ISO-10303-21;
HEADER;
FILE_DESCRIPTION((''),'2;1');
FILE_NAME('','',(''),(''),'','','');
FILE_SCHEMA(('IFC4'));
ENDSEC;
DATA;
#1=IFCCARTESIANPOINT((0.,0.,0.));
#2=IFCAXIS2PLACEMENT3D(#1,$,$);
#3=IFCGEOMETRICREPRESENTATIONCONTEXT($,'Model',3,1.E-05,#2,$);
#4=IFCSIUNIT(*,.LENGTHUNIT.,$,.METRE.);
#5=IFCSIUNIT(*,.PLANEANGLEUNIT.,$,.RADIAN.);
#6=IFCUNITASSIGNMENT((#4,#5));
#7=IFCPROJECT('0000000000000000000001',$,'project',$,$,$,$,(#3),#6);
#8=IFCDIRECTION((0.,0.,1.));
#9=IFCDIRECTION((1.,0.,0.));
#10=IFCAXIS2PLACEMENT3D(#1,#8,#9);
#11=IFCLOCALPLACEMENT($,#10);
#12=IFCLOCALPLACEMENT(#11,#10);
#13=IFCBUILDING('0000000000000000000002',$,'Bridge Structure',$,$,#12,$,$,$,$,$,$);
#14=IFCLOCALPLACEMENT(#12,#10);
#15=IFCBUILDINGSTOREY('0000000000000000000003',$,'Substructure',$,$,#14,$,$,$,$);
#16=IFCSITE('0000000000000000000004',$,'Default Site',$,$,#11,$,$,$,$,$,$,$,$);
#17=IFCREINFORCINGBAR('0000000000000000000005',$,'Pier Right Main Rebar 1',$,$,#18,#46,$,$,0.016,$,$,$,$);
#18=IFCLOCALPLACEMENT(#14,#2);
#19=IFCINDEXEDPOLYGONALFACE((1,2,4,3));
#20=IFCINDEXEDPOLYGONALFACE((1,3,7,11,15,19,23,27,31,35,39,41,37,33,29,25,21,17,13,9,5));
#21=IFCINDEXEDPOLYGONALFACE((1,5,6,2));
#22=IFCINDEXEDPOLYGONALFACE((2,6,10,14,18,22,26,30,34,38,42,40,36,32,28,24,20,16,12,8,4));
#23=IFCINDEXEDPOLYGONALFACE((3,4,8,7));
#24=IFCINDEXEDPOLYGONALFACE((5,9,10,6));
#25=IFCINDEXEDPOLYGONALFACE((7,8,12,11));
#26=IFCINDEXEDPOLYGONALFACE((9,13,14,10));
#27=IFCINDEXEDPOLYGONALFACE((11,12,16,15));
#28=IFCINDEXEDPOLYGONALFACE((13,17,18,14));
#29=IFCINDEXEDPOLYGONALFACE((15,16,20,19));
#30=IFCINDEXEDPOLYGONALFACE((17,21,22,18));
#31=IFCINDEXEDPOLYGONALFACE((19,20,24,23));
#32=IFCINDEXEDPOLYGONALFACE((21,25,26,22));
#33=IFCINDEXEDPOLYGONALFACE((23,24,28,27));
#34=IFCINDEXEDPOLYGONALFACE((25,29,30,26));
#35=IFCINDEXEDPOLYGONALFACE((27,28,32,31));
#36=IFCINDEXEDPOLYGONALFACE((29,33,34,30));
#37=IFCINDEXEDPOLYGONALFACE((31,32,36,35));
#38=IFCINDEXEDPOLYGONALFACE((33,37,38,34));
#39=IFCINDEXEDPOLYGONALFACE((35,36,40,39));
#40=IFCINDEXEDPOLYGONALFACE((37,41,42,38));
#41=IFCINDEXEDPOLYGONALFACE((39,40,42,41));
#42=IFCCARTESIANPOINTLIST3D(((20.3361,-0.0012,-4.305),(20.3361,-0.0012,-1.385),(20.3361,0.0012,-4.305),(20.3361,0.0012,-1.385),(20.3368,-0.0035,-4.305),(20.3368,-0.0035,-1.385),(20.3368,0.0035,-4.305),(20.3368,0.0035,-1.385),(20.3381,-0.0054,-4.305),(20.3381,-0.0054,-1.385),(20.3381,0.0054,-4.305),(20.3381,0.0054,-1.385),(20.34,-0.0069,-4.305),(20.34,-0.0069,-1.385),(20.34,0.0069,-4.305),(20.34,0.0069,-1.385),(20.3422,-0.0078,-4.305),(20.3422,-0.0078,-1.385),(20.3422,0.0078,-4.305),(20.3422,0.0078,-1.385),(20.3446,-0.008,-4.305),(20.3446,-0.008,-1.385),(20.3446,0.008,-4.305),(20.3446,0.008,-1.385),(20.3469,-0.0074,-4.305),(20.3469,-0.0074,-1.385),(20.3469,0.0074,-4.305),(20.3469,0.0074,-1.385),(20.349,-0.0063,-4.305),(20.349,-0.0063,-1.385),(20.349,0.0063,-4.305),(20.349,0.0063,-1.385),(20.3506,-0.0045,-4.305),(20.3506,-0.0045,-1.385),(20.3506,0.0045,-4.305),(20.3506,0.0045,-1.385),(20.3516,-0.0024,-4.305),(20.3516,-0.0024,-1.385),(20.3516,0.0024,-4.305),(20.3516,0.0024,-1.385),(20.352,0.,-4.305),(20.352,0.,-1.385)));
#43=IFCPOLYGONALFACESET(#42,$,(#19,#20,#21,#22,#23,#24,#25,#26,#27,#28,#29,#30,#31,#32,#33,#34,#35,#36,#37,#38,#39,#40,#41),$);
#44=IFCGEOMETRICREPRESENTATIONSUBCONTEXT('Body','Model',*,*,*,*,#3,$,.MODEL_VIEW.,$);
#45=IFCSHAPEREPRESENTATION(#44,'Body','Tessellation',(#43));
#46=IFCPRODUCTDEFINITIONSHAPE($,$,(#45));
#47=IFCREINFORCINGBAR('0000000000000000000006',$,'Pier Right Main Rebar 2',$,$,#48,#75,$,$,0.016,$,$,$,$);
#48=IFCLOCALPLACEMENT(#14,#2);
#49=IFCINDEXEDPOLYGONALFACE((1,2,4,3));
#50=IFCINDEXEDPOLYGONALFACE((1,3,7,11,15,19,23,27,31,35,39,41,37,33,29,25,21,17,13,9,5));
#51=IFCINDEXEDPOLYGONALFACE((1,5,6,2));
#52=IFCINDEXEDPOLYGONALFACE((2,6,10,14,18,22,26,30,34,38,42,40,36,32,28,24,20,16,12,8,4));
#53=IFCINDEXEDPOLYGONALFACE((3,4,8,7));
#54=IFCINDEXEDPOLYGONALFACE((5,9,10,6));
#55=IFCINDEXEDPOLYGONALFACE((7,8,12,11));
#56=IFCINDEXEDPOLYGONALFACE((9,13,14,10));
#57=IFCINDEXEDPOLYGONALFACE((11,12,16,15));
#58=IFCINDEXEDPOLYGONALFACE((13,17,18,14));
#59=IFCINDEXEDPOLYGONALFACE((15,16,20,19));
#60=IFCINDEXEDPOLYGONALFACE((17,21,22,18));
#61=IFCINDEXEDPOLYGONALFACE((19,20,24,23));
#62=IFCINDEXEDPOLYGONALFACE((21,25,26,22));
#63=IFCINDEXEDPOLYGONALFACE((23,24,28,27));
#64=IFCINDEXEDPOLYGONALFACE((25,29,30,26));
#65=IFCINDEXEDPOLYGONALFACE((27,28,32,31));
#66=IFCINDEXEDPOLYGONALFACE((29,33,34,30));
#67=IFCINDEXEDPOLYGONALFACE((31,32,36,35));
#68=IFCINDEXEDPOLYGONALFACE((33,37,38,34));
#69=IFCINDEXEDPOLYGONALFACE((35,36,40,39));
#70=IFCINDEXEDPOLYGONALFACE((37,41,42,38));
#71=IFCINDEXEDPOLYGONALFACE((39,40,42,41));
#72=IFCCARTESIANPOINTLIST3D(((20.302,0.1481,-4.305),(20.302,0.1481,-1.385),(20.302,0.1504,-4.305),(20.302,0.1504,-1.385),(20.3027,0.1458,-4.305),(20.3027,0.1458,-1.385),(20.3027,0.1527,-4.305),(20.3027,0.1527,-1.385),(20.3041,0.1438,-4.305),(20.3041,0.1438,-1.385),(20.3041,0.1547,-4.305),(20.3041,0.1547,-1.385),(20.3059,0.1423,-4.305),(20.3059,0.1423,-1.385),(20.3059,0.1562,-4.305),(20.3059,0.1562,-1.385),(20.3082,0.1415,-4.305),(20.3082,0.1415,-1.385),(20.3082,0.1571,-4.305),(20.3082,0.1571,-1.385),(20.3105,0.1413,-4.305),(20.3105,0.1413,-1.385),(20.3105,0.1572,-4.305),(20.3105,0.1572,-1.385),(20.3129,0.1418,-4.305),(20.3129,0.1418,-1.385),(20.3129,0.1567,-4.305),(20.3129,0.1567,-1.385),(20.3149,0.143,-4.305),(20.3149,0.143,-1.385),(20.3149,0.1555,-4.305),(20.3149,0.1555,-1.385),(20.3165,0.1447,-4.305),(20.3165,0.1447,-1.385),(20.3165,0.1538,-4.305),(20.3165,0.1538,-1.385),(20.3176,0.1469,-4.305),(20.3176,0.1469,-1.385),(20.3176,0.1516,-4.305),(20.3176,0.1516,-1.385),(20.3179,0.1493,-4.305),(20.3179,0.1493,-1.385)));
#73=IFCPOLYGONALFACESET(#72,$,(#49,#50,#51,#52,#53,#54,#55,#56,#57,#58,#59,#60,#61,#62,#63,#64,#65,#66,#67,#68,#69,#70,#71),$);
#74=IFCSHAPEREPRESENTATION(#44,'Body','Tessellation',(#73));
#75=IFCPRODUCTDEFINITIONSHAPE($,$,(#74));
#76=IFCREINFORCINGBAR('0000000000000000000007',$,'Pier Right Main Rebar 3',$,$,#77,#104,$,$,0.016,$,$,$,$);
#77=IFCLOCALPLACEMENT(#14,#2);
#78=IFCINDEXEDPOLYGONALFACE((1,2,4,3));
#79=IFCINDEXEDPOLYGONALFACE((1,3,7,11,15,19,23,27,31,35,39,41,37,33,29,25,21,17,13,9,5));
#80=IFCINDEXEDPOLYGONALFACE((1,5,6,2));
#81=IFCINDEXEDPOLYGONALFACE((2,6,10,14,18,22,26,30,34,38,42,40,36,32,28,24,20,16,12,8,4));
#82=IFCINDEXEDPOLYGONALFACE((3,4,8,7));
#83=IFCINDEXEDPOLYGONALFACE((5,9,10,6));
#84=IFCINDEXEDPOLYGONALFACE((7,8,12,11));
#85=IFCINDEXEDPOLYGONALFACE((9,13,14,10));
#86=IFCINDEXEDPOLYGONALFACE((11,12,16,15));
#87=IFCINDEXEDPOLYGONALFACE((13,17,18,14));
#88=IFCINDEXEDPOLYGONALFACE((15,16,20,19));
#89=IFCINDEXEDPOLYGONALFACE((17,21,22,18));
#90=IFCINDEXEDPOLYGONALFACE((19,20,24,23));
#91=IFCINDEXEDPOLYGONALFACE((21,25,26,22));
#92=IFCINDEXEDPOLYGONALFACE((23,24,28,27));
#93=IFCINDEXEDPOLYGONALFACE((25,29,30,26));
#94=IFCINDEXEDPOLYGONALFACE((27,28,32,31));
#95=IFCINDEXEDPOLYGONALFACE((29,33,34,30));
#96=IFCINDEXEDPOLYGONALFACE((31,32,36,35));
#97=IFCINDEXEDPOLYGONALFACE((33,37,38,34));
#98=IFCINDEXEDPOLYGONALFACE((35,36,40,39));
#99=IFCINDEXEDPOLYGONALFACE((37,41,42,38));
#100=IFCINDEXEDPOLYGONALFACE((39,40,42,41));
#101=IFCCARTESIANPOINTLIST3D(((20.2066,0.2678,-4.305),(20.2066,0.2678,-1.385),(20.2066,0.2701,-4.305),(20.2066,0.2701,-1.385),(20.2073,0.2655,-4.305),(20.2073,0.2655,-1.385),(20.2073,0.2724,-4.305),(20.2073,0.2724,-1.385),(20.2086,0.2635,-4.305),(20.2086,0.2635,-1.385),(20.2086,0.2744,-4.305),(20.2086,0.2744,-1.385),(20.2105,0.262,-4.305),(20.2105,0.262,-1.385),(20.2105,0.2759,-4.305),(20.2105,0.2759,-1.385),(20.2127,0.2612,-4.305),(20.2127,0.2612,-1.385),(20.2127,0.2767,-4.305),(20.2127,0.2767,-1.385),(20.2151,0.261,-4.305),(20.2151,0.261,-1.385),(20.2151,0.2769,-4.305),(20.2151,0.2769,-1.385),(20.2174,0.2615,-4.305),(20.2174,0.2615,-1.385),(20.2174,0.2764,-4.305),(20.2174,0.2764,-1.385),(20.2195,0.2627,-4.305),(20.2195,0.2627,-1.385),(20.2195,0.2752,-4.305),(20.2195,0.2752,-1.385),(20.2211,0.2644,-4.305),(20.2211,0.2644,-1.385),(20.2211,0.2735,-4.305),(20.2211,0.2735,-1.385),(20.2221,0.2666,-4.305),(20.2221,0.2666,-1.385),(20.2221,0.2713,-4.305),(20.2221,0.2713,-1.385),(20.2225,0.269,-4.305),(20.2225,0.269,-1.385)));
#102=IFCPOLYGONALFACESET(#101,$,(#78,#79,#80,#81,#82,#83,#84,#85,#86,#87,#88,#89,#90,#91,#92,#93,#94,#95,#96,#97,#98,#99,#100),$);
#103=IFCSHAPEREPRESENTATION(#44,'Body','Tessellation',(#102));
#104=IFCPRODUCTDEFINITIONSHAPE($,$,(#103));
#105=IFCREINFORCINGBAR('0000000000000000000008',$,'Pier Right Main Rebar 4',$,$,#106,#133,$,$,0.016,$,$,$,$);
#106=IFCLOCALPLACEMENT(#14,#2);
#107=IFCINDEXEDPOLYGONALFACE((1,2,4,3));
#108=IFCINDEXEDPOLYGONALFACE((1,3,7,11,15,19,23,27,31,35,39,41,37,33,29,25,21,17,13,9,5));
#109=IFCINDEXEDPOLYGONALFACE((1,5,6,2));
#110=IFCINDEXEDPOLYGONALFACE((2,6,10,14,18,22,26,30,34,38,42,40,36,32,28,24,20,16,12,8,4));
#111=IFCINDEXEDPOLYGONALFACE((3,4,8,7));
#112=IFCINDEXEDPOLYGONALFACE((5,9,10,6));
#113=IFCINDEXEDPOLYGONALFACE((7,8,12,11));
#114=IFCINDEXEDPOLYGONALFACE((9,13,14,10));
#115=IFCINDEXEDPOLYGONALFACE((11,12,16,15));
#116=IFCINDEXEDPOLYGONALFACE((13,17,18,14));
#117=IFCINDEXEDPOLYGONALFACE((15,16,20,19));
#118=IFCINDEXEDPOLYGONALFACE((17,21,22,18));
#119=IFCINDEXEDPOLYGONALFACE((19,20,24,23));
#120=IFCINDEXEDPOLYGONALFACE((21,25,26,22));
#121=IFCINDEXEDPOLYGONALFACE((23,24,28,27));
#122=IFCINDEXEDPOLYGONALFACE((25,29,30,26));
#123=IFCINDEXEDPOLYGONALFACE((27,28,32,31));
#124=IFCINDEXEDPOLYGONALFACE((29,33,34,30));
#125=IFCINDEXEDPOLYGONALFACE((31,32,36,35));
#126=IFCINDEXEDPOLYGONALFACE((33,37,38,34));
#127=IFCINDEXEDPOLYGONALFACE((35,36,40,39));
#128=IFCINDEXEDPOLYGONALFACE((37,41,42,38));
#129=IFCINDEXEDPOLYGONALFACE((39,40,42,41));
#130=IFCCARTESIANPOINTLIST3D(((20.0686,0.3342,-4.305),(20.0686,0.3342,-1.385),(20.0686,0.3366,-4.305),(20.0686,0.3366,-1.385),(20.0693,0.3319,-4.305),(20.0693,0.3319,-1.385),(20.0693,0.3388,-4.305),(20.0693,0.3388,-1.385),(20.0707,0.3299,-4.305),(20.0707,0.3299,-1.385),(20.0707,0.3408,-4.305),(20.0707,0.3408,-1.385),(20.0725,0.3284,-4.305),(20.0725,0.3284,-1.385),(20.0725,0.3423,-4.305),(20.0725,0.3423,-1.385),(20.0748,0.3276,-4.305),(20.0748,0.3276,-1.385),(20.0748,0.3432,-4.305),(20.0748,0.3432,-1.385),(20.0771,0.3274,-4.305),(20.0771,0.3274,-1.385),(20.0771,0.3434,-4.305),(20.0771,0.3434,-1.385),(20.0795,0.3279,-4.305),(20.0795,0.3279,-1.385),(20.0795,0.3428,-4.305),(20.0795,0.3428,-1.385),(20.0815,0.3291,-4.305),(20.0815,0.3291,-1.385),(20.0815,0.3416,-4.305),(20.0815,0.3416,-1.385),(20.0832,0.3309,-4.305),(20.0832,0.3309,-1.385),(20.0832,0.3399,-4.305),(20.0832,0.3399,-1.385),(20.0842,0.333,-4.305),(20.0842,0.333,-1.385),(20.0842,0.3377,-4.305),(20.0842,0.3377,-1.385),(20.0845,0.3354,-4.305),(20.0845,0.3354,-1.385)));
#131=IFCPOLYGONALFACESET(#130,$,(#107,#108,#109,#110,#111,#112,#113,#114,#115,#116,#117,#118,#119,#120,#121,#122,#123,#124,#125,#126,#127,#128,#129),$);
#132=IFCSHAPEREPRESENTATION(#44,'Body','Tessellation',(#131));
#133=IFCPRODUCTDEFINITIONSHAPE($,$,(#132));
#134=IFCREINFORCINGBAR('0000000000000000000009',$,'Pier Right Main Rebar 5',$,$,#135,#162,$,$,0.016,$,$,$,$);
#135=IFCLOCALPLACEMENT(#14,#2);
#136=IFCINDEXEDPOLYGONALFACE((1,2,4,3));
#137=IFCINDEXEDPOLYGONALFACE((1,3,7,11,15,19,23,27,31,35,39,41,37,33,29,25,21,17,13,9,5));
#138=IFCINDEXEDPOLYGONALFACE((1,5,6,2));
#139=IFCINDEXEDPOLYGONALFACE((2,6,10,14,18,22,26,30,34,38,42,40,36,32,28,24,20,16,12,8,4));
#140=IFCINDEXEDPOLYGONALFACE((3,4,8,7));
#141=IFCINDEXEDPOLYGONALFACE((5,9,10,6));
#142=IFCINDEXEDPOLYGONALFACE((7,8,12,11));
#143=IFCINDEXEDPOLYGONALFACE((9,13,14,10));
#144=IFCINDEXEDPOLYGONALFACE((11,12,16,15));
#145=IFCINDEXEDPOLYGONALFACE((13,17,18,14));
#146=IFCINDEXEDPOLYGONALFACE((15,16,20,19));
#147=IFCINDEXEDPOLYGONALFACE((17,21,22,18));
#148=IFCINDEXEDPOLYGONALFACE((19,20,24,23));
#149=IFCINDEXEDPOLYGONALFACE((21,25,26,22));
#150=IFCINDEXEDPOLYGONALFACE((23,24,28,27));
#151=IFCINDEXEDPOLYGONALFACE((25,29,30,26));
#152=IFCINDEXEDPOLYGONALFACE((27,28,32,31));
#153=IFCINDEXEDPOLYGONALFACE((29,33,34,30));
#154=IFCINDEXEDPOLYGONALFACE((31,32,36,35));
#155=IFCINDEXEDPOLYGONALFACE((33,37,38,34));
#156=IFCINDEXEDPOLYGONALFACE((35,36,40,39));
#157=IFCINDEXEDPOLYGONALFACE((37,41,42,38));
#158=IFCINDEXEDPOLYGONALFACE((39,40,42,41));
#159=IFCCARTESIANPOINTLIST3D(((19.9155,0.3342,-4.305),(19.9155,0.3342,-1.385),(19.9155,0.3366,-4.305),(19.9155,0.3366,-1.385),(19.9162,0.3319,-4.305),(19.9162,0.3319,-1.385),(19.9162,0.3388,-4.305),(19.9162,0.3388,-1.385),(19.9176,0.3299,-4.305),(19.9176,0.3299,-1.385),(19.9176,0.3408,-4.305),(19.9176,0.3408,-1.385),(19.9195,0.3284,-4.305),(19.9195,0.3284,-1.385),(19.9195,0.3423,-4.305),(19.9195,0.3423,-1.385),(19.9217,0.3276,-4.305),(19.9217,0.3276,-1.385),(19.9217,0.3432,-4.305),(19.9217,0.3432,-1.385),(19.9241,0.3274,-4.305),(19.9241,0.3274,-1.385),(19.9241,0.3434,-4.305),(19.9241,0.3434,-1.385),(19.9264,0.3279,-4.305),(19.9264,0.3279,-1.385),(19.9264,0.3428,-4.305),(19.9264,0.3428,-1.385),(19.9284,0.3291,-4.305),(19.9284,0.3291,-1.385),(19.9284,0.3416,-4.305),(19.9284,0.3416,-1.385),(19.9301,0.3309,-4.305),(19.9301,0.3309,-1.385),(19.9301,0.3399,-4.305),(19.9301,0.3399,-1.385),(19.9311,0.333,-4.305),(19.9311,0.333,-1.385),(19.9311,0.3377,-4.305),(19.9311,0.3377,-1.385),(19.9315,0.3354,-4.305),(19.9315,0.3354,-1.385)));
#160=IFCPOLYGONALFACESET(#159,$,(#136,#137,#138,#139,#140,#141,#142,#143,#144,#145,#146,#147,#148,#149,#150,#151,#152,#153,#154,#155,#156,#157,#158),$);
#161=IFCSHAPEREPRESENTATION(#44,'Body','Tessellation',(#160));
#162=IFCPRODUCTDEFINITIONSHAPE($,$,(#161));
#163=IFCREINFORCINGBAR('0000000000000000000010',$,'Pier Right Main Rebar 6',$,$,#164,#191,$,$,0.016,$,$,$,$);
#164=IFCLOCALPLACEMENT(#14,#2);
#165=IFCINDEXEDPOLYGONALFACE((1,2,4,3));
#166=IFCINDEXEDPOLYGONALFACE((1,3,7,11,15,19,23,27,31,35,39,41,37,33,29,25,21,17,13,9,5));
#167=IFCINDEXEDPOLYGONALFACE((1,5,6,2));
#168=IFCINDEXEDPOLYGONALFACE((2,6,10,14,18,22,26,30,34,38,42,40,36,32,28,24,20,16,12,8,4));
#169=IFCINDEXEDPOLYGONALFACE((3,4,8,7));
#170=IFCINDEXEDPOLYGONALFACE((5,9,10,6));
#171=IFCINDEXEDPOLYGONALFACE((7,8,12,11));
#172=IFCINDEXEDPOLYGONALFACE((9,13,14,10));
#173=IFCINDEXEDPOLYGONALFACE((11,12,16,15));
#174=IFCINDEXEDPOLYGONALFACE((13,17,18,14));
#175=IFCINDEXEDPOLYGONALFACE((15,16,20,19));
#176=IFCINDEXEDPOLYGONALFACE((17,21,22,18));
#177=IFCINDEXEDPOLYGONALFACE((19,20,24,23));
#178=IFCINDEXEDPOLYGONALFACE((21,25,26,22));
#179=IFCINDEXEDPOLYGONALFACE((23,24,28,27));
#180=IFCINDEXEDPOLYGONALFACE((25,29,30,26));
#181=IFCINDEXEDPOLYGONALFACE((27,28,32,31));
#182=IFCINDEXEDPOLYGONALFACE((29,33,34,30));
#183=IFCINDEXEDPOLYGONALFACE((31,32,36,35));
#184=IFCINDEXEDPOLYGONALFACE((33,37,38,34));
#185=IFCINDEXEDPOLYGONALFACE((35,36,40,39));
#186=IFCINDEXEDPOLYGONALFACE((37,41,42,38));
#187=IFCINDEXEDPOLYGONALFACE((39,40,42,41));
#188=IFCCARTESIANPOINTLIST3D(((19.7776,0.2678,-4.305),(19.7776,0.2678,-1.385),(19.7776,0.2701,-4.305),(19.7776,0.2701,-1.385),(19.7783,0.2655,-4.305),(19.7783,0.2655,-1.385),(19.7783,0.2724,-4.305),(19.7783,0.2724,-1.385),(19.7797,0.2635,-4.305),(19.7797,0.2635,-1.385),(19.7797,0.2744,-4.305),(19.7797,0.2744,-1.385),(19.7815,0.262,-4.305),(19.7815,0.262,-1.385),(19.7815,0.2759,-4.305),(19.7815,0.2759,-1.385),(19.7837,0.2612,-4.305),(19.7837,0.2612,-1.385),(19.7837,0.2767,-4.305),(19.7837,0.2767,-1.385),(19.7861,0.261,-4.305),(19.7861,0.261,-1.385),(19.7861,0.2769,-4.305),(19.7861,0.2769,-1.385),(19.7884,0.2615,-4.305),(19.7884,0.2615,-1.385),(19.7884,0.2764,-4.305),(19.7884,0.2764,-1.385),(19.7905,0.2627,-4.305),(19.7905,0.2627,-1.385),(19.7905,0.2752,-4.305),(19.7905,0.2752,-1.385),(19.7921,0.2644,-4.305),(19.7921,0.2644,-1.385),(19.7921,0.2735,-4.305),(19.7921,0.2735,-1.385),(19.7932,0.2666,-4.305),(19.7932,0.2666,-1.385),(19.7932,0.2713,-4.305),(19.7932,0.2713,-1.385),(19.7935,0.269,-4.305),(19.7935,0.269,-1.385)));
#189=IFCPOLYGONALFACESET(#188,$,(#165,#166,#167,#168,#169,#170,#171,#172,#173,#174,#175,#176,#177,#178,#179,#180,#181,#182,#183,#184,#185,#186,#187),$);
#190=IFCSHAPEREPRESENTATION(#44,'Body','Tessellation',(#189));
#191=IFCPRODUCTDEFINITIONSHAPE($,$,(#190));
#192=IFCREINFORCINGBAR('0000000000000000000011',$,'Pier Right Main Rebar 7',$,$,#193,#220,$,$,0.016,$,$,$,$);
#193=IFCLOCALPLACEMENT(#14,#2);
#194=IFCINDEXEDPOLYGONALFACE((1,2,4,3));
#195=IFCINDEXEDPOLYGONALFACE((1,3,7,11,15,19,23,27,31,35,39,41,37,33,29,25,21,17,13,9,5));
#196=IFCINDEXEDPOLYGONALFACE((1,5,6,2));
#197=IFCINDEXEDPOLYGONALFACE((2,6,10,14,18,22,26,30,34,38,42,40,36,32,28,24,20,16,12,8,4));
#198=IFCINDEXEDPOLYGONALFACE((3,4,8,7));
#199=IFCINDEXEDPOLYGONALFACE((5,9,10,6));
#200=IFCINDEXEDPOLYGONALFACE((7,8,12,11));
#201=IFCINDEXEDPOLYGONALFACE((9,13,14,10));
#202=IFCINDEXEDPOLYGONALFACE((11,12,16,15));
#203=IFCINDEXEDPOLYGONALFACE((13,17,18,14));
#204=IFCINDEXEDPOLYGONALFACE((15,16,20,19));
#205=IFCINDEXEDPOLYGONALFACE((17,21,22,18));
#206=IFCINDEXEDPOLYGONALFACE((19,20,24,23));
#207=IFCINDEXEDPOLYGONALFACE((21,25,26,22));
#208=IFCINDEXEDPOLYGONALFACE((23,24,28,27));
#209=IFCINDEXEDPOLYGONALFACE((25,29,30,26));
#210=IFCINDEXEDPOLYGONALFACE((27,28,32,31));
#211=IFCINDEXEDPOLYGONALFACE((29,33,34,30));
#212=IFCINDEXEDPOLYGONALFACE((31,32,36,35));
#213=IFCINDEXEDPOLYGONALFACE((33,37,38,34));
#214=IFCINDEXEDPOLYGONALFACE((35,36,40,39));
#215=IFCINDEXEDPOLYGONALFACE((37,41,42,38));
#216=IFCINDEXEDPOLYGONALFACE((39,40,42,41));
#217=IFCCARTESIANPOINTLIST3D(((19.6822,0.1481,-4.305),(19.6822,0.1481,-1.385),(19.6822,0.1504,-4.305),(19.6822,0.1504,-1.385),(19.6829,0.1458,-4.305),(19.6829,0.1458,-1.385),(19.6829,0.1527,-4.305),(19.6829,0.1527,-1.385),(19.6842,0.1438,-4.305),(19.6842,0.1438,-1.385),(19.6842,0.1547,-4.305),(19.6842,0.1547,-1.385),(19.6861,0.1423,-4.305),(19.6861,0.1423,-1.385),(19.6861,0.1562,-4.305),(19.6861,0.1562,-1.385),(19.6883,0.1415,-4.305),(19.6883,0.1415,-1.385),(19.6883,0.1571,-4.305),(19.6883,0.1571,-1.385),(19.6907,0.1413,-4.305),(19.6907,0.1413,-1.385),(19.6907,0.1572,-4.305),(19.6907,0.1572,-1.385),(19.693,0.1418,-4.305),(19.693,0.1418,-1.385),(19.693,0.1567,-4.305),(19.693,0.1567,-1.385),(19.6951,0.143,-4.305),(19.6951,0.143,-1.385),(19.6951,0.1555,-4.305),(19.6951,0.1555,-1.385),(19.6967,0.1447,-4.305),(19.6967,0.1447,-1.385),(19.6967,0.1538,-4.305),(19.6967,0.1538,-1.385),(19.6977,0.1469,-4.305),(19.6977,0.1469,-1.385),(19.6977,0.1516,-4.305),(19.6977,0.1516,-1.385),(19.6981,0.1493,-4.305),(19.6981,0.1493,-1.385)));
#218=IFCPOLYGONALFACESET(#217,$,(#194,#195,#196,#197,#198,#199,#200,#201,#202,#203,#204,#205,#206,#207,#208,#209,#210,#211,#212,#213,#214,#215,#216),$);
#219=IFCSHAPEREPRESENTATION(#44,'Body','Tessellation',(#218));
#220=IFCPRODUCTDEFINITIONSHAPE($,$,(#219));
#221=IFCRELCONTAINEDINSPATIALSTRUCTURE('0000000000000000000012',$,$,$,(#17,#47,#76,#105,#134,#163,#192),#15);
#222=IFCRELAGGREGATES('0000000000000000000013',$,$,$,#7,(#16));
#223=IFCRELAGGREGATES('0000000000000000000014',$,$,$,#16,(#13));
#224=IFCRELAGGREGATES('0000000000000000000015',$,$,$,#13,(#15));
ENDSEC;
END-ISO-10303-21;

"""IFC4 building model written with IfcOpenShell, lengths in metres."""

from ifc_helpers import new_model, si_unit, frame, origin, origin_with_axes, origin_2d_with_axis, place, context, subcontext, project, spatial, circle, extrude, element, save


model = new_model("IFC4")

# Units and contexts
model_context = context("Model", 3, precision=1e-05, world=origin())
body_context = subcontext(model_context, "Body", "Model", "MODEL_VIEW")
ifc_project = project(units=[si_unit("LENGTHUNIT", "METRE"), si_unit("PLANEANGLEUNIT", "RADIAN")], contexts=[model_context])

# Site, building, storey
site_placement = place(None, origin_with_axes())
site = spatial("IfcSite", under=ifc_project, at=site_placement, Name="Default Site")
building_placement = place(site_placement, origin_with_axes())
building = spatial("IfcBuilding", under=site, at=building_placement, Name="Bridge Structure")
storey_placement = place(building_placement, origin_with_axes())
storey = spatial("IfcBuildingStorey", under=building, at=storey_placement, Name="Substructure")

# Reinforcing bars
for number, where, z_axis, x_axis, name in (
    (1, (20.344, 0.0, -4.305), (0.0, 0.0, 1.0), (1.0, 0.0, 0.0), "Pier Right Main Rebar 1"),
    (2, (20.3099, 0.1493, -4.305), (0.0, 0.0, 1.0), (1.0, 0.0, 0.0), "Pier Right Main Rebar 2"),
    (3, (20.2145, 0.269, -4.305), (0.0, 0.0, 1.0), (1.0, 0.0, 0.0), "Pier Right Main Rebar 3"),
    (4, (20.0765, 0.3354, -4.305), (0.0, 0.0, 1.0), (1.0, 0.0, 0.0), "Pier Right Main Rebar 4"),
    (5, (19.9235, 0.3354, -4.305), (0.0, 0.0, 1.0), (1.0, 0.0, 0.0), "Pier Right Main Rebar 5"),
    (6, (19.7855, 0.269, -4.305), (0.0, 0.0, 1.0), (1.0, 0.0, 0.0), "Pier Right Main Rebar 6"),
    (7, (19.6901, 0.1493, -4.305), (0.0, 0.0, 1.0), (1.0, 0.0, 0.0), "Pier Right Main Rebar 7"),
):
    element("IfcReinforcingBar", number, at=place(storey_placement, frame(where, z_axis=z_axis, x_axis=x_axis)), inside=storey, Name=name, NominalDiameter=0.016, context=body_context, shape_type="SweptSolid", body=[
        extrude(circle(Radius=0.008, at=origin_2d_with_axis()), origin_with_axes(), (0.0, 0.0, 1.0), 2.92),
    ])

save(model, "model.ifc")
